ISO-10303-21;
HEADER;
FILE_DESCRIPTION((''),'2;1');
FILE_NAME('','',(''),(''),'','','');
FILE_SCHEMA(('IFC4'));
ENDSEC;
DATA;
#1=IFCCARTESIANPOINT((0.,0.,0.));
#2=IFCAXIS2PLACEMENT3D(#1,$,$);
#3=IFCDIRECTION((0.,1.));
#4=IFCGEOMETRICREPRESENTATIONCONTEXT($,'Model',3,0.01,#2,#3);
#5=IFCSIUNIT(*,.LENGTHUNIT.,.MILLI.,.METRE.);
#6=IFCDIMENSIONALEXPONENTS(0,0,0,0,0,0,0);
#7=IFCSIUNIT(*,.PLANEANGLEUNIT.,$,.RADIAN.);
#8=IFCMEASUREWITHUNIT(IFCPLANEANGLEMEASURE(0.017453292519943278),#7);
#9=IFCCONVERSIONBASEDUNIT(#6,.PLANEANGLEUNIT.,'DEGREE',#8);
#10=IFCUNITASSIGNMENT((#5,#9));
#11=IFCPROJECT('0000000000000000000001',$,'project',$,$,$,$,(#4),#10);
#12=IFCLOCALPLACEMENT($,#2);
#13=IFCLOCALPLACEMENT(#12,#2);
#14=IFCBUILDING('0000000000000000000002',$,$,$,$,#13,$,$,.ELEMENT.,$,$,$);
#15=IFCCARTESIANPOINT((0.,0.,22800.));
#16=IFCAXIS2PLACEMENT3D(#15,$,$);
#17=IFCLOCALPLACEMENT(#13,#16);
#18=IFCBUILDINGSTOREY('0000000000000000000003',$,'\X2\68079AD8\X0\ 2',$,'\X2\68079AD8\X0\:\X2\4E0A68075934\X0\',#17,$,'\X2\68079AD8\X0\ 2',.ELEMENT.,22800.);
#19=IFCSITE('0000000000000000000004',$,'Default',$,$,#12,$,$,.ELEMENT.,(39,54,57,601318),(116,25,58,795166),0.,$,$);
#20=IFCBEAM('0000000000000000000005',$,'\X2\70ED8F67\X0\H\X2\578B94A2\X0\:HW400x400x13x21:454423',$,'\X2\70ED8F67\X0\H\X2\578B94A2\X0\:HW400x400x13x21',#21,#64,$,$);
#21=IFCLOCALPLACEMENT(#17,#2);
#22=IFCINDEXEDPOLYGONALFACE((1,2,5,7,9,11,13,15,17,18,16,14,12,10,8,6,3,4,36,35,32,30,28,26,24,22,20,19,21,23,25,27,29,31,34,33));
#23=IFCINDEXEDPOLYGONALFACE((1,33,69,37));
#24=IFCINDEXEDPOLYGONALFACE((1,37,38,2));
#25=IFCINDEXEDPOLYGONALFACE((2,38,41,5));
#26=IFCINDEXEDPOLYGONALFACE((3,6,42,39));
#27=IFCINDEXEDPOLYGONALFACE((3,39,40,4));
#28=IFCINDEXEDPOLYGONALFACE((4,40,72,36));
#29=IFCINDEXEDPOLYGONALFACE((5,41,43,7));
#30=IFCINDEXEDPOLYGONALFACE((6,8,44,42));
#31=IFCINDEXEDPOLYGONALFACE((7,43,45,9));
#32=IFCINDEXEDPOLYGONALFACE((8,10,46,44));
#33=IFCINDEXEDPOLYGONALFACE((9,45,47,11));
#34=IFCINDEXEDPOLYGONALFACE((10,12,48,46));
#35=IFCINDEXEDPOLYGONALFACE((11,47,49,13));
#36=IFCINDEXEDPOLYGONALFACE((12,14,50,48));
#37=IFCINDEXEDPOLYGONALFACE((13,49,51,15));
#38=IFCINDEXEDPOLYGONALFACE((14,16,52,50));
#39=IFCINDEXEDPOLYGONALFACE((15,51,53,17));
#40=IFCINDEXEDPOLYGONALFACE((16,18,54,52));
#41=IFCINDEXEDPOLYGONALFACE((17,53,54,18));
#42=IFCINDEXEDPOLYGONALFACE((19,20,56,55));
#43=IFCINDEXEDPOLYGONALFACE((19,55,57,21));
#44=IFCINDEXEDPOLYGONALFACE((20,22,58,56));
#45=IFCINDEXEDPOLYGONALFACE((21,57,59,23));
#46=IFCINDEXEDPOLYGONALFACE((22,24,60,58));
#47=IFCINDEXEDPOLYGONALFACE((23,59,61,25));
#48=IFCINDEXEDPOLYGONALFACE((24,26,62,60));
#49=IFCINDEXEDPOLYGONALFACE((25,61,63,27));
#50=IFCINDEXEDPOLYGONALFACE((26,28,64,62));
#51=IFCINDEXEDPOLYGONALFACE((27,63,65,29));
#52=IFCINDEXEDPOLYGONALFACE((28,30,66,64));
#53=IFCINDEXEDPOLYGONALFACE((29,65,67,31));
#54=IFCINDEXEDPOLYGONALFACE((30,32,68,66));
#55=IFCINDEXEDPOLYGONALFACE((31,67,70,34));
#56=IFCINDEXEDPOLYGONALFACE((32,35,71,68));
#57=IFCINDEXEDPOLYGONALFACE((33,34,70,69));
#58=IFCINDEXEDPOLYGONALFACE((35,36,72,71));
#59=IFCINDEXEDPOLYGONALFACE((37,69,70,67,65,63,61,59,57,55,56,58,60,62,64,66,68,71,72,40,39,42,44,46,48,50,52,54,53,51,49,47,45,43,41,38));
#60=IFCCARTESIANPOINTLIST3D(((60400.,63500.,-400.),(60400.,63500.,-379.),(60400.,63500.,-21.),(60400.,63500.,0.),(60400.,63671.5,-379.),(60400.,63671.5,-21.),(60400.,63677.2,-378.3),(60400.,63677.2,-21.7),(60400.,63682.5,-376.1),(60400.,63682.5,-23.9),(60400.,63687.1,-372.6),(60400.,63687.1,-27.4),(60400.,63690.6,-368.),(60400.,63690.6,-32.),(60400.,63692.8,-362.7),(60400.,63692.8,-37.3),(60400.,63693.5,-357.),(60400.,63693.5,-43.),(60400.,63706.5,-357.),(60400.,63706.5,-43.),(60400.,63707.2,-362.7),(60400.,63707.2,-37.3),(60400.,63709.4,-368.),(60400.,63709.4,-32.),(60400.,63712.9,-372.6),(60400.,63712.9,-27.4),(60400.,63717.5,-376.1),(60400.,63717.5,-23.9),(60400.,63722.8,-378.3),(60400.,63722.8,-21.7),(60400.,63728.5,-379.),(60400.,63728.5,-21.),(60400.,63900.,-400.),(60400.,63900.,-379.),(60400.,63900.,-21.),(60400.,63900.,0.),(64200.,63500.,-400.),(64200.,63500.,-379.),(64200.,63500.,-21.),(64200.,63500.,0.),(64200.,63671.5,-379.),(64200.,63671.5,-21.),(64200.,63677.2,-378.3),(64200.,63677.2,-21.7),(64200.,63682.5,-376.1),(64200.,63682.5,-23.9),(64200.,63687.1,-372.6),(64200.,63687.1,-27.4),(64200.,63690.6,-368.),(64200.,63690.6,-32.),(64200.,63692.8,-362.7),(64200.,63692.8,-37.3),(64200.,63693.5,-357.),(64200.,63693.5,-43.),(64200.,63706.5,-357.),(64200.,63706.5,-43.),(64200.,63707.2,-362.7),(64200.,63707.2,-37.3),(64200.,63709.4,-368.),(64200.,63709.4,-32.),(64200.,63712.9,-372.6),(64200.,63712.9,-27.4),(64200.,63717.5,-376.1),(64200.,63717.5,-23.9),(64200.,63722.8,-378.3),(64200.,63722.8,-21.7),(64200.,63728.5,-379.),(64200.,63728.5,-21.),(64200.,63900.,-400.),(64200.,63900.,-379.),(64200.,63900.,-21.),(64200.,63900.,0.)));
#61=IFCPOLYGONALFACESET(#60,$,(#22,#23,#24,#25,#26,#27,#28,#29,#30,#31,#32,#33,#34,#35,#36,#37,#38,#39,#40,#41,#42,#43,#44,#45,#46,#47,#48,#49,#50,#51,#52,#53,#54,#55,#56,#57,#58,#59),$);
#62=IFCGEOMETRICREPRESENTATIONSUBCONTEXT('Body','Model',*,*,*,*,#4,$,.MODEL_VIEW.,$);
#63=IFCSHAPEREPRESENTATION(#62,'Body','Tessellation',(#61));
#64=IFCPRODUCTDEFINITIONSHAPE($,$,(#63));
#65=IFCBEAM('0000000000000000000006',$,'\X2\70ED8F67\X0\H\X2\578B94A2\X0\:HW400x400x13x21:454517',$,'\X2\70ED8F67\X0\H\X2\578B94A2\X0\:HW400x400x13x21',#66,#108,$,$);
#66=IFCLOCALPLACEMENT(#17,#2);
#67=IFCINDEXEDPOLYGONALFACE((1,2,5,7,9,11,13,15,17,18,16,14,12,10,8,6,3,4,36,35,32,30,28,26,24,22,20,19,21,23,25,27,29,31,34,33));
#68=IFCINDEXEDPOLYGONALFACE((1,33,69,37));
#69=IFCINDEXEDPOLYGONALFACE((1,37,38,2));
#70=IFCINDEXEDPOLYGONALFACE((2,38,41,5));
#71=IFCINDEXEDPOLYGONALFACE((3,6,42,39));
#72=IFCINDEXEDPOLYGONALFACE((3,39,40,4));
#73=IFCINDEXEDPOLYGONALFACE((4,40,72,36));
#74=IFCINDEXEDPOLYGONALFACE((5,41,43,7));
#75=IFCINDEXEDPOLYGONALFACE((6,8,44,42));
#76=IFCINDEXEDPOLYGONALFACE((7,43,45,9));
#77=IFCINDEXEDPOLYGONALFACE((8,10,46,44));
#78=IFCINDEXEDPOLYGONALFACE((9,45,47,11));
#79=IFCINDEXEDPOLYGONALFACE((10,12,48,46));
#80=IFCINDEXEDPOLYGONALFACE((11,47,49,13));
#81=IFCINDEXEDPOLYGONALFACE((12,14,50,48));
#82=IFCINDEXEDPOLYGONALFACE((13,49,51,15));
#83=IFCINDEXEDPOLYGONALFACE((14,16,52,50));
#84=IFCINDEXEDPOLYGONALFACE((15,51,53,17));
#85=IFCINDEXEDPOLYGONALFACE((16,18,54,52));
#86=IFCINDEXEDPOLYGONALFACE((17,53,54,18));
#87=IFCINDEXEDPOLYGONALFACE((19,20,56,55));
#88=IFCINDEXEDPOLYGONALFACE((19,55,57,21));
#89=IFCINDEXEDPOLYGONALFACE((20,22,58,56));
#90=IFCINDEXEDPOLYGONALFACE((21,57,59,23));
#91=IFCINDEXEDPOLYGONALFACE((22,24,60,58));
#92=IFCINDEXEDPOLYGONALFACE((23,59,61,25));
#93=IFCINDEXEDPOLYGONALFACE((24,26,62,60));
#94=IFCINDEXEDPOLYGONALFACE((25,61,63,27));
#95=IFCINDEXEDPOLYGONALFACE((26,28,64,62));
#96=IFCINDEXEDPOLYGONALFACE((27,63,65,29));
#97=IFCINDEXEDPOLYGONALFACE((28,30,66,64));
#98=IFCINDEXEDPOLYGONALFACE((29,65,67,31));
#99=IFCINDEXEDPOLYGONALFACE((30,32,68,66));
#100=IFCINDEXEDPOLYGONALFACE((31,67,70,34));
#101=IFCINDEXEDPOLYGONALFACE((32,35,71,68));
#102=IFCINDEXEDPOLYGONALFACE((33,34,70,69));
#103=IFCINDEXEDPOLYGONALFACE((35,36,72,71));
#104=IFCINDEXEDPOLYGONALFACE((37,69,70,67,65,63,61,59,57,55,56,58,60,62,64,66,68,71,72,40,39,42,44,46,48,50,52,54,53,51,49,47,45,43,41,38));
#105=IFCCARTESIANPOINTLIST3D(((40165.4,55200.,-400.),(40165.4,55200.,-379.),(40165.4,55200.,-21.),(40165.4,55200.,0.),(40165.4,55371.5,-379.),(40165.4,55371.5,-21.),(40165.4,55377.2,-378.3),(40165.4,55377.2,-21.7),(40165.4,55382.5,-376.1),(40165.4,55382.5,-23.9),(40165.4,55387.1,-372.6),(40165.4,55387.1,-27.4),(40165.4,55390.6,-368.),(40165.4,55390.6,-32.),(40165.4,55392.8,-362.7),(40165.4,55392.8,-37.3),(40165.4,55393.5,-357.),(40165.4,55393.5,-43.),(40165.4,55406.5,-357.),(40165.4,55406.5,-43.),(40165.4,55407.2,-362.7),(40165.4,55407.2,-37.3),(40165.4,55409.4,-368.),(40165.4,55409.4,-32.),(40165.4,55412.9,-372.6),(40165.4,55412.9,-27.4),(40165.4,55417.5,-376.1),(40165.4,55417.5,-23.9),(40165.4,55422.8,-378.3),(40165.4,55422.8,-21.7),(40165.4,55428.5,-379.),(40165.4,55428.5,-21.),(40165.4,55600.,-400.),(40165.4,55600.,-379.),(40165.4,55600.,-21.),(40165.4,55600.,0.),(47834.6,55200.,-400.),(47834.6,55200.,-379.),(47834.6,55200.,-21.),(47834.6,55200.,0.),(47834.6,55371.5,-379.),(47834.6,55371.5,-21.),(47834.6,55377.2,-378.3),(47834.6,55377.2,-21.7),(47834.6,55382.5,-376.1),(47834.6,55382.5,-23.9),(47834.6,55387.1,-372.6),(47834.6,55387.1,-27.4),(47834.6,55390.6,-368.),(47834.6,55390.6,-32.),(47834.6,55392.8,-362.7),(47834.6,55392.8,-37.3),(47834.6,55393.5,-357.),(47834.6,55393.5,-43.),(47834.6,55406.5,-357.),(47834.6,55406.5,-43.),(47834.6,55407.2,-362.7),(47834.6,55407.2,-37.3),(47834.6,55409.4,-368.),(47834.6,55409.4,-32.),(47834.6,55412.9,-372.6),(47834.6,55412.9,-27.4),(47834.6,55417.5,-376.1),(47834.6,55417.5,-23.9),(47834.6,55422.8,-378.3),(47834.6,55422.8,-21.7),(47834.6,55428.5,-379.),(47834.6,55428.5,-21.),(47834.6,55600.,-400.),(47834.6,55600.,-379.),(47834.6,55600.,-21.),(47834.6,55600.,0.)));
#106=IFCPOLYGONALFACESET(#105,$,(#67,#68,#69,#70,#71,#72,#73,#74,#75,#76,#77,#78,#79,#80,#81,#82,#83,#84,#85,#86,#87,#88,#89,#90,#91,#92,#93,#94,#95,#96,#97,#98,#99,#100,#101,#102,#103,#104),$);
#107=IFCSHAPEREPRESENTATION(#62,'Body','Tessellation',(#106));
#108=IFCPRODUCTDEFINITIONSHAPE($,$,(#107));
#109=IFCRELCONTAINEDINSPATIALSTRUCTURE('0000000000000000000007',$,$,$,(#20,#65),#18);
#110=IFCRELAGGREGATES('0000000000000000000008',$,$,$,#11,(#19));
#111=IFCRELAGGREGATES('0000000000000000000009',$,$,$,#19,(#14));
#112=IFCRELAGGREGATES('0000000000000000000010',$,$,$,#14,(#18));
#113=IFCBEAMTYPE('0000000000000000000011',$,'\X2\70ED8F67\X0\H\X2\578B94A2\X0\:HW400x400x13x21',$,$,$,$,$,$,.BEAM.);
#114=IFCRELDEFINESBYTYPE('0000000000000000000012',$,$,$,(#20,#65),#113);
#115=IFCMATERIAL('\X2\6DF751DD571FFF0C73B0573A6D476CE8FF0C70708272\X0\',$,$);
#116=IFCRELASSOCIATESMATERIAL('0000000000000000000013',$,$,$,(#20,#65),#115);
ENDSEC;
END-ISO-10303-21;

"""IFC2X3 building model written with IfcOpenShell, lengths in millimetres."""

from ifc_helpers import new_model, entity, si_unit, converted_unit, direction, frame, frame_2d, origin, place, context, subcontext, project, spatial, i_section, extrude, material, type_object, element, save


model = new_model("IFC2X3")

# Units and contexts
model_context = context("Model", 3, precision=0.01, world=origin(), true_north=direction((0.0, 1.0)))
body_context = subcontext(model_context, "Body", "Model", "MODEL_VIEW")
ifc_project = project(units=[si_unit("LENGTHUNIT", "METRE", prefix="MILLI"), converted_unit("PLANEANGLEUNIT", "DEGREE", entity("IfcPlaneAngleMeasure", 0.017453292519943278), si_unit("PLANEANGLEUNIT", "RADIAN"), dimensions=[0, 0, 0, 0, 0, 0, 0])], contexts=[model_context])

# Site, building, storey
site_placement = place(None, origin())
site = spatial("IfcSite", under=ifc_project, at=site_placement, Name="Default", CompositionType="ELEMENT", RefLatitude=(39, 54, 57, 601318), RefLongitude=(116, 25, 58, 795166), RefElevation=0.0)
building_placement = place(site_placement, origin())
building = spatial("IfcBuilding", under=site, at=building_placement, CompositionType="ELEMENT")
storey_placement = place(building_placement, frame((0.0, 0.0, 22800.0)))
storey = spatial("IfcBuildingStorey", under=building, at=storey_placement, Name="标高 2", ObjectType="标高:上标头", LongName="标高 2", CompositionType="ELEMENT", Elevation=22800.0)

# Beams
ifc_material = material(Name="混凝土，现场浇注，灰色")
beam_type = type_object("IfcBeamType", Name="热轧H型钢:HW400x400x13x21", PredefinedType="BEAM")
beam_1_placement = place(storey_placement, frame((60600.0, 63700.0, 0.0)))
element("IfcBeam", 1, at=beam_1_placement, inside=storey, type_object=beam_type, material=ifc_material, Name="热轧H型钢:HW400x400x13x21:454423", ObjectType="热轧H型钢:HW400x400x13x21", context=body_context, shape_type="SweptSolid", body=[
    extrude(i_section(OverallWidth=400.0, OverallDepth=400.0, WebThickness=13.0, FlangeThickness=21.0, FilletRadius=22.0, at=frame_2d((0.0, 0.0), x_axis=(0.0, 1.0))), frame((-200.0, 0.0, -200.0), z_axis=(1.0, 0.0, 0.0), x_axis=(0.0, 0.0, -1.0)), (0.0, 0.0, 1.0), 3800.0),
])
beam_2_placement = place(storey_placement, frame((40100.0, 55400.0, 0.0)))
element("IfcBeam", 2, at=beam_2_placement, inside=storey, type_object=beam_type, material=ifc_material, Name="热轧H型钢:HW400x400x13x21:454517", ObjectType="热轧H型钢:HW400x400x13x21", context=body_context, shape_type="SweptSolid", body=[
    extrude(i_section(OverallWidth=400.0, OverallDepth=400.0, WebThickness=13.0, FlangeThickness=21.0, FilletRadius=22.0, at=frame_2d((0.0, 0.0), x_axis=(0.0, 1.0))), frame((65.4, 0.0, -200.0), z_axis=(1.0, 0.0, 0.0), x_axis=(0.0, 0.0, -1.0)), (0.0, 0.0, 1.0), 7669.2),
])

save(model, "model.ifc")
